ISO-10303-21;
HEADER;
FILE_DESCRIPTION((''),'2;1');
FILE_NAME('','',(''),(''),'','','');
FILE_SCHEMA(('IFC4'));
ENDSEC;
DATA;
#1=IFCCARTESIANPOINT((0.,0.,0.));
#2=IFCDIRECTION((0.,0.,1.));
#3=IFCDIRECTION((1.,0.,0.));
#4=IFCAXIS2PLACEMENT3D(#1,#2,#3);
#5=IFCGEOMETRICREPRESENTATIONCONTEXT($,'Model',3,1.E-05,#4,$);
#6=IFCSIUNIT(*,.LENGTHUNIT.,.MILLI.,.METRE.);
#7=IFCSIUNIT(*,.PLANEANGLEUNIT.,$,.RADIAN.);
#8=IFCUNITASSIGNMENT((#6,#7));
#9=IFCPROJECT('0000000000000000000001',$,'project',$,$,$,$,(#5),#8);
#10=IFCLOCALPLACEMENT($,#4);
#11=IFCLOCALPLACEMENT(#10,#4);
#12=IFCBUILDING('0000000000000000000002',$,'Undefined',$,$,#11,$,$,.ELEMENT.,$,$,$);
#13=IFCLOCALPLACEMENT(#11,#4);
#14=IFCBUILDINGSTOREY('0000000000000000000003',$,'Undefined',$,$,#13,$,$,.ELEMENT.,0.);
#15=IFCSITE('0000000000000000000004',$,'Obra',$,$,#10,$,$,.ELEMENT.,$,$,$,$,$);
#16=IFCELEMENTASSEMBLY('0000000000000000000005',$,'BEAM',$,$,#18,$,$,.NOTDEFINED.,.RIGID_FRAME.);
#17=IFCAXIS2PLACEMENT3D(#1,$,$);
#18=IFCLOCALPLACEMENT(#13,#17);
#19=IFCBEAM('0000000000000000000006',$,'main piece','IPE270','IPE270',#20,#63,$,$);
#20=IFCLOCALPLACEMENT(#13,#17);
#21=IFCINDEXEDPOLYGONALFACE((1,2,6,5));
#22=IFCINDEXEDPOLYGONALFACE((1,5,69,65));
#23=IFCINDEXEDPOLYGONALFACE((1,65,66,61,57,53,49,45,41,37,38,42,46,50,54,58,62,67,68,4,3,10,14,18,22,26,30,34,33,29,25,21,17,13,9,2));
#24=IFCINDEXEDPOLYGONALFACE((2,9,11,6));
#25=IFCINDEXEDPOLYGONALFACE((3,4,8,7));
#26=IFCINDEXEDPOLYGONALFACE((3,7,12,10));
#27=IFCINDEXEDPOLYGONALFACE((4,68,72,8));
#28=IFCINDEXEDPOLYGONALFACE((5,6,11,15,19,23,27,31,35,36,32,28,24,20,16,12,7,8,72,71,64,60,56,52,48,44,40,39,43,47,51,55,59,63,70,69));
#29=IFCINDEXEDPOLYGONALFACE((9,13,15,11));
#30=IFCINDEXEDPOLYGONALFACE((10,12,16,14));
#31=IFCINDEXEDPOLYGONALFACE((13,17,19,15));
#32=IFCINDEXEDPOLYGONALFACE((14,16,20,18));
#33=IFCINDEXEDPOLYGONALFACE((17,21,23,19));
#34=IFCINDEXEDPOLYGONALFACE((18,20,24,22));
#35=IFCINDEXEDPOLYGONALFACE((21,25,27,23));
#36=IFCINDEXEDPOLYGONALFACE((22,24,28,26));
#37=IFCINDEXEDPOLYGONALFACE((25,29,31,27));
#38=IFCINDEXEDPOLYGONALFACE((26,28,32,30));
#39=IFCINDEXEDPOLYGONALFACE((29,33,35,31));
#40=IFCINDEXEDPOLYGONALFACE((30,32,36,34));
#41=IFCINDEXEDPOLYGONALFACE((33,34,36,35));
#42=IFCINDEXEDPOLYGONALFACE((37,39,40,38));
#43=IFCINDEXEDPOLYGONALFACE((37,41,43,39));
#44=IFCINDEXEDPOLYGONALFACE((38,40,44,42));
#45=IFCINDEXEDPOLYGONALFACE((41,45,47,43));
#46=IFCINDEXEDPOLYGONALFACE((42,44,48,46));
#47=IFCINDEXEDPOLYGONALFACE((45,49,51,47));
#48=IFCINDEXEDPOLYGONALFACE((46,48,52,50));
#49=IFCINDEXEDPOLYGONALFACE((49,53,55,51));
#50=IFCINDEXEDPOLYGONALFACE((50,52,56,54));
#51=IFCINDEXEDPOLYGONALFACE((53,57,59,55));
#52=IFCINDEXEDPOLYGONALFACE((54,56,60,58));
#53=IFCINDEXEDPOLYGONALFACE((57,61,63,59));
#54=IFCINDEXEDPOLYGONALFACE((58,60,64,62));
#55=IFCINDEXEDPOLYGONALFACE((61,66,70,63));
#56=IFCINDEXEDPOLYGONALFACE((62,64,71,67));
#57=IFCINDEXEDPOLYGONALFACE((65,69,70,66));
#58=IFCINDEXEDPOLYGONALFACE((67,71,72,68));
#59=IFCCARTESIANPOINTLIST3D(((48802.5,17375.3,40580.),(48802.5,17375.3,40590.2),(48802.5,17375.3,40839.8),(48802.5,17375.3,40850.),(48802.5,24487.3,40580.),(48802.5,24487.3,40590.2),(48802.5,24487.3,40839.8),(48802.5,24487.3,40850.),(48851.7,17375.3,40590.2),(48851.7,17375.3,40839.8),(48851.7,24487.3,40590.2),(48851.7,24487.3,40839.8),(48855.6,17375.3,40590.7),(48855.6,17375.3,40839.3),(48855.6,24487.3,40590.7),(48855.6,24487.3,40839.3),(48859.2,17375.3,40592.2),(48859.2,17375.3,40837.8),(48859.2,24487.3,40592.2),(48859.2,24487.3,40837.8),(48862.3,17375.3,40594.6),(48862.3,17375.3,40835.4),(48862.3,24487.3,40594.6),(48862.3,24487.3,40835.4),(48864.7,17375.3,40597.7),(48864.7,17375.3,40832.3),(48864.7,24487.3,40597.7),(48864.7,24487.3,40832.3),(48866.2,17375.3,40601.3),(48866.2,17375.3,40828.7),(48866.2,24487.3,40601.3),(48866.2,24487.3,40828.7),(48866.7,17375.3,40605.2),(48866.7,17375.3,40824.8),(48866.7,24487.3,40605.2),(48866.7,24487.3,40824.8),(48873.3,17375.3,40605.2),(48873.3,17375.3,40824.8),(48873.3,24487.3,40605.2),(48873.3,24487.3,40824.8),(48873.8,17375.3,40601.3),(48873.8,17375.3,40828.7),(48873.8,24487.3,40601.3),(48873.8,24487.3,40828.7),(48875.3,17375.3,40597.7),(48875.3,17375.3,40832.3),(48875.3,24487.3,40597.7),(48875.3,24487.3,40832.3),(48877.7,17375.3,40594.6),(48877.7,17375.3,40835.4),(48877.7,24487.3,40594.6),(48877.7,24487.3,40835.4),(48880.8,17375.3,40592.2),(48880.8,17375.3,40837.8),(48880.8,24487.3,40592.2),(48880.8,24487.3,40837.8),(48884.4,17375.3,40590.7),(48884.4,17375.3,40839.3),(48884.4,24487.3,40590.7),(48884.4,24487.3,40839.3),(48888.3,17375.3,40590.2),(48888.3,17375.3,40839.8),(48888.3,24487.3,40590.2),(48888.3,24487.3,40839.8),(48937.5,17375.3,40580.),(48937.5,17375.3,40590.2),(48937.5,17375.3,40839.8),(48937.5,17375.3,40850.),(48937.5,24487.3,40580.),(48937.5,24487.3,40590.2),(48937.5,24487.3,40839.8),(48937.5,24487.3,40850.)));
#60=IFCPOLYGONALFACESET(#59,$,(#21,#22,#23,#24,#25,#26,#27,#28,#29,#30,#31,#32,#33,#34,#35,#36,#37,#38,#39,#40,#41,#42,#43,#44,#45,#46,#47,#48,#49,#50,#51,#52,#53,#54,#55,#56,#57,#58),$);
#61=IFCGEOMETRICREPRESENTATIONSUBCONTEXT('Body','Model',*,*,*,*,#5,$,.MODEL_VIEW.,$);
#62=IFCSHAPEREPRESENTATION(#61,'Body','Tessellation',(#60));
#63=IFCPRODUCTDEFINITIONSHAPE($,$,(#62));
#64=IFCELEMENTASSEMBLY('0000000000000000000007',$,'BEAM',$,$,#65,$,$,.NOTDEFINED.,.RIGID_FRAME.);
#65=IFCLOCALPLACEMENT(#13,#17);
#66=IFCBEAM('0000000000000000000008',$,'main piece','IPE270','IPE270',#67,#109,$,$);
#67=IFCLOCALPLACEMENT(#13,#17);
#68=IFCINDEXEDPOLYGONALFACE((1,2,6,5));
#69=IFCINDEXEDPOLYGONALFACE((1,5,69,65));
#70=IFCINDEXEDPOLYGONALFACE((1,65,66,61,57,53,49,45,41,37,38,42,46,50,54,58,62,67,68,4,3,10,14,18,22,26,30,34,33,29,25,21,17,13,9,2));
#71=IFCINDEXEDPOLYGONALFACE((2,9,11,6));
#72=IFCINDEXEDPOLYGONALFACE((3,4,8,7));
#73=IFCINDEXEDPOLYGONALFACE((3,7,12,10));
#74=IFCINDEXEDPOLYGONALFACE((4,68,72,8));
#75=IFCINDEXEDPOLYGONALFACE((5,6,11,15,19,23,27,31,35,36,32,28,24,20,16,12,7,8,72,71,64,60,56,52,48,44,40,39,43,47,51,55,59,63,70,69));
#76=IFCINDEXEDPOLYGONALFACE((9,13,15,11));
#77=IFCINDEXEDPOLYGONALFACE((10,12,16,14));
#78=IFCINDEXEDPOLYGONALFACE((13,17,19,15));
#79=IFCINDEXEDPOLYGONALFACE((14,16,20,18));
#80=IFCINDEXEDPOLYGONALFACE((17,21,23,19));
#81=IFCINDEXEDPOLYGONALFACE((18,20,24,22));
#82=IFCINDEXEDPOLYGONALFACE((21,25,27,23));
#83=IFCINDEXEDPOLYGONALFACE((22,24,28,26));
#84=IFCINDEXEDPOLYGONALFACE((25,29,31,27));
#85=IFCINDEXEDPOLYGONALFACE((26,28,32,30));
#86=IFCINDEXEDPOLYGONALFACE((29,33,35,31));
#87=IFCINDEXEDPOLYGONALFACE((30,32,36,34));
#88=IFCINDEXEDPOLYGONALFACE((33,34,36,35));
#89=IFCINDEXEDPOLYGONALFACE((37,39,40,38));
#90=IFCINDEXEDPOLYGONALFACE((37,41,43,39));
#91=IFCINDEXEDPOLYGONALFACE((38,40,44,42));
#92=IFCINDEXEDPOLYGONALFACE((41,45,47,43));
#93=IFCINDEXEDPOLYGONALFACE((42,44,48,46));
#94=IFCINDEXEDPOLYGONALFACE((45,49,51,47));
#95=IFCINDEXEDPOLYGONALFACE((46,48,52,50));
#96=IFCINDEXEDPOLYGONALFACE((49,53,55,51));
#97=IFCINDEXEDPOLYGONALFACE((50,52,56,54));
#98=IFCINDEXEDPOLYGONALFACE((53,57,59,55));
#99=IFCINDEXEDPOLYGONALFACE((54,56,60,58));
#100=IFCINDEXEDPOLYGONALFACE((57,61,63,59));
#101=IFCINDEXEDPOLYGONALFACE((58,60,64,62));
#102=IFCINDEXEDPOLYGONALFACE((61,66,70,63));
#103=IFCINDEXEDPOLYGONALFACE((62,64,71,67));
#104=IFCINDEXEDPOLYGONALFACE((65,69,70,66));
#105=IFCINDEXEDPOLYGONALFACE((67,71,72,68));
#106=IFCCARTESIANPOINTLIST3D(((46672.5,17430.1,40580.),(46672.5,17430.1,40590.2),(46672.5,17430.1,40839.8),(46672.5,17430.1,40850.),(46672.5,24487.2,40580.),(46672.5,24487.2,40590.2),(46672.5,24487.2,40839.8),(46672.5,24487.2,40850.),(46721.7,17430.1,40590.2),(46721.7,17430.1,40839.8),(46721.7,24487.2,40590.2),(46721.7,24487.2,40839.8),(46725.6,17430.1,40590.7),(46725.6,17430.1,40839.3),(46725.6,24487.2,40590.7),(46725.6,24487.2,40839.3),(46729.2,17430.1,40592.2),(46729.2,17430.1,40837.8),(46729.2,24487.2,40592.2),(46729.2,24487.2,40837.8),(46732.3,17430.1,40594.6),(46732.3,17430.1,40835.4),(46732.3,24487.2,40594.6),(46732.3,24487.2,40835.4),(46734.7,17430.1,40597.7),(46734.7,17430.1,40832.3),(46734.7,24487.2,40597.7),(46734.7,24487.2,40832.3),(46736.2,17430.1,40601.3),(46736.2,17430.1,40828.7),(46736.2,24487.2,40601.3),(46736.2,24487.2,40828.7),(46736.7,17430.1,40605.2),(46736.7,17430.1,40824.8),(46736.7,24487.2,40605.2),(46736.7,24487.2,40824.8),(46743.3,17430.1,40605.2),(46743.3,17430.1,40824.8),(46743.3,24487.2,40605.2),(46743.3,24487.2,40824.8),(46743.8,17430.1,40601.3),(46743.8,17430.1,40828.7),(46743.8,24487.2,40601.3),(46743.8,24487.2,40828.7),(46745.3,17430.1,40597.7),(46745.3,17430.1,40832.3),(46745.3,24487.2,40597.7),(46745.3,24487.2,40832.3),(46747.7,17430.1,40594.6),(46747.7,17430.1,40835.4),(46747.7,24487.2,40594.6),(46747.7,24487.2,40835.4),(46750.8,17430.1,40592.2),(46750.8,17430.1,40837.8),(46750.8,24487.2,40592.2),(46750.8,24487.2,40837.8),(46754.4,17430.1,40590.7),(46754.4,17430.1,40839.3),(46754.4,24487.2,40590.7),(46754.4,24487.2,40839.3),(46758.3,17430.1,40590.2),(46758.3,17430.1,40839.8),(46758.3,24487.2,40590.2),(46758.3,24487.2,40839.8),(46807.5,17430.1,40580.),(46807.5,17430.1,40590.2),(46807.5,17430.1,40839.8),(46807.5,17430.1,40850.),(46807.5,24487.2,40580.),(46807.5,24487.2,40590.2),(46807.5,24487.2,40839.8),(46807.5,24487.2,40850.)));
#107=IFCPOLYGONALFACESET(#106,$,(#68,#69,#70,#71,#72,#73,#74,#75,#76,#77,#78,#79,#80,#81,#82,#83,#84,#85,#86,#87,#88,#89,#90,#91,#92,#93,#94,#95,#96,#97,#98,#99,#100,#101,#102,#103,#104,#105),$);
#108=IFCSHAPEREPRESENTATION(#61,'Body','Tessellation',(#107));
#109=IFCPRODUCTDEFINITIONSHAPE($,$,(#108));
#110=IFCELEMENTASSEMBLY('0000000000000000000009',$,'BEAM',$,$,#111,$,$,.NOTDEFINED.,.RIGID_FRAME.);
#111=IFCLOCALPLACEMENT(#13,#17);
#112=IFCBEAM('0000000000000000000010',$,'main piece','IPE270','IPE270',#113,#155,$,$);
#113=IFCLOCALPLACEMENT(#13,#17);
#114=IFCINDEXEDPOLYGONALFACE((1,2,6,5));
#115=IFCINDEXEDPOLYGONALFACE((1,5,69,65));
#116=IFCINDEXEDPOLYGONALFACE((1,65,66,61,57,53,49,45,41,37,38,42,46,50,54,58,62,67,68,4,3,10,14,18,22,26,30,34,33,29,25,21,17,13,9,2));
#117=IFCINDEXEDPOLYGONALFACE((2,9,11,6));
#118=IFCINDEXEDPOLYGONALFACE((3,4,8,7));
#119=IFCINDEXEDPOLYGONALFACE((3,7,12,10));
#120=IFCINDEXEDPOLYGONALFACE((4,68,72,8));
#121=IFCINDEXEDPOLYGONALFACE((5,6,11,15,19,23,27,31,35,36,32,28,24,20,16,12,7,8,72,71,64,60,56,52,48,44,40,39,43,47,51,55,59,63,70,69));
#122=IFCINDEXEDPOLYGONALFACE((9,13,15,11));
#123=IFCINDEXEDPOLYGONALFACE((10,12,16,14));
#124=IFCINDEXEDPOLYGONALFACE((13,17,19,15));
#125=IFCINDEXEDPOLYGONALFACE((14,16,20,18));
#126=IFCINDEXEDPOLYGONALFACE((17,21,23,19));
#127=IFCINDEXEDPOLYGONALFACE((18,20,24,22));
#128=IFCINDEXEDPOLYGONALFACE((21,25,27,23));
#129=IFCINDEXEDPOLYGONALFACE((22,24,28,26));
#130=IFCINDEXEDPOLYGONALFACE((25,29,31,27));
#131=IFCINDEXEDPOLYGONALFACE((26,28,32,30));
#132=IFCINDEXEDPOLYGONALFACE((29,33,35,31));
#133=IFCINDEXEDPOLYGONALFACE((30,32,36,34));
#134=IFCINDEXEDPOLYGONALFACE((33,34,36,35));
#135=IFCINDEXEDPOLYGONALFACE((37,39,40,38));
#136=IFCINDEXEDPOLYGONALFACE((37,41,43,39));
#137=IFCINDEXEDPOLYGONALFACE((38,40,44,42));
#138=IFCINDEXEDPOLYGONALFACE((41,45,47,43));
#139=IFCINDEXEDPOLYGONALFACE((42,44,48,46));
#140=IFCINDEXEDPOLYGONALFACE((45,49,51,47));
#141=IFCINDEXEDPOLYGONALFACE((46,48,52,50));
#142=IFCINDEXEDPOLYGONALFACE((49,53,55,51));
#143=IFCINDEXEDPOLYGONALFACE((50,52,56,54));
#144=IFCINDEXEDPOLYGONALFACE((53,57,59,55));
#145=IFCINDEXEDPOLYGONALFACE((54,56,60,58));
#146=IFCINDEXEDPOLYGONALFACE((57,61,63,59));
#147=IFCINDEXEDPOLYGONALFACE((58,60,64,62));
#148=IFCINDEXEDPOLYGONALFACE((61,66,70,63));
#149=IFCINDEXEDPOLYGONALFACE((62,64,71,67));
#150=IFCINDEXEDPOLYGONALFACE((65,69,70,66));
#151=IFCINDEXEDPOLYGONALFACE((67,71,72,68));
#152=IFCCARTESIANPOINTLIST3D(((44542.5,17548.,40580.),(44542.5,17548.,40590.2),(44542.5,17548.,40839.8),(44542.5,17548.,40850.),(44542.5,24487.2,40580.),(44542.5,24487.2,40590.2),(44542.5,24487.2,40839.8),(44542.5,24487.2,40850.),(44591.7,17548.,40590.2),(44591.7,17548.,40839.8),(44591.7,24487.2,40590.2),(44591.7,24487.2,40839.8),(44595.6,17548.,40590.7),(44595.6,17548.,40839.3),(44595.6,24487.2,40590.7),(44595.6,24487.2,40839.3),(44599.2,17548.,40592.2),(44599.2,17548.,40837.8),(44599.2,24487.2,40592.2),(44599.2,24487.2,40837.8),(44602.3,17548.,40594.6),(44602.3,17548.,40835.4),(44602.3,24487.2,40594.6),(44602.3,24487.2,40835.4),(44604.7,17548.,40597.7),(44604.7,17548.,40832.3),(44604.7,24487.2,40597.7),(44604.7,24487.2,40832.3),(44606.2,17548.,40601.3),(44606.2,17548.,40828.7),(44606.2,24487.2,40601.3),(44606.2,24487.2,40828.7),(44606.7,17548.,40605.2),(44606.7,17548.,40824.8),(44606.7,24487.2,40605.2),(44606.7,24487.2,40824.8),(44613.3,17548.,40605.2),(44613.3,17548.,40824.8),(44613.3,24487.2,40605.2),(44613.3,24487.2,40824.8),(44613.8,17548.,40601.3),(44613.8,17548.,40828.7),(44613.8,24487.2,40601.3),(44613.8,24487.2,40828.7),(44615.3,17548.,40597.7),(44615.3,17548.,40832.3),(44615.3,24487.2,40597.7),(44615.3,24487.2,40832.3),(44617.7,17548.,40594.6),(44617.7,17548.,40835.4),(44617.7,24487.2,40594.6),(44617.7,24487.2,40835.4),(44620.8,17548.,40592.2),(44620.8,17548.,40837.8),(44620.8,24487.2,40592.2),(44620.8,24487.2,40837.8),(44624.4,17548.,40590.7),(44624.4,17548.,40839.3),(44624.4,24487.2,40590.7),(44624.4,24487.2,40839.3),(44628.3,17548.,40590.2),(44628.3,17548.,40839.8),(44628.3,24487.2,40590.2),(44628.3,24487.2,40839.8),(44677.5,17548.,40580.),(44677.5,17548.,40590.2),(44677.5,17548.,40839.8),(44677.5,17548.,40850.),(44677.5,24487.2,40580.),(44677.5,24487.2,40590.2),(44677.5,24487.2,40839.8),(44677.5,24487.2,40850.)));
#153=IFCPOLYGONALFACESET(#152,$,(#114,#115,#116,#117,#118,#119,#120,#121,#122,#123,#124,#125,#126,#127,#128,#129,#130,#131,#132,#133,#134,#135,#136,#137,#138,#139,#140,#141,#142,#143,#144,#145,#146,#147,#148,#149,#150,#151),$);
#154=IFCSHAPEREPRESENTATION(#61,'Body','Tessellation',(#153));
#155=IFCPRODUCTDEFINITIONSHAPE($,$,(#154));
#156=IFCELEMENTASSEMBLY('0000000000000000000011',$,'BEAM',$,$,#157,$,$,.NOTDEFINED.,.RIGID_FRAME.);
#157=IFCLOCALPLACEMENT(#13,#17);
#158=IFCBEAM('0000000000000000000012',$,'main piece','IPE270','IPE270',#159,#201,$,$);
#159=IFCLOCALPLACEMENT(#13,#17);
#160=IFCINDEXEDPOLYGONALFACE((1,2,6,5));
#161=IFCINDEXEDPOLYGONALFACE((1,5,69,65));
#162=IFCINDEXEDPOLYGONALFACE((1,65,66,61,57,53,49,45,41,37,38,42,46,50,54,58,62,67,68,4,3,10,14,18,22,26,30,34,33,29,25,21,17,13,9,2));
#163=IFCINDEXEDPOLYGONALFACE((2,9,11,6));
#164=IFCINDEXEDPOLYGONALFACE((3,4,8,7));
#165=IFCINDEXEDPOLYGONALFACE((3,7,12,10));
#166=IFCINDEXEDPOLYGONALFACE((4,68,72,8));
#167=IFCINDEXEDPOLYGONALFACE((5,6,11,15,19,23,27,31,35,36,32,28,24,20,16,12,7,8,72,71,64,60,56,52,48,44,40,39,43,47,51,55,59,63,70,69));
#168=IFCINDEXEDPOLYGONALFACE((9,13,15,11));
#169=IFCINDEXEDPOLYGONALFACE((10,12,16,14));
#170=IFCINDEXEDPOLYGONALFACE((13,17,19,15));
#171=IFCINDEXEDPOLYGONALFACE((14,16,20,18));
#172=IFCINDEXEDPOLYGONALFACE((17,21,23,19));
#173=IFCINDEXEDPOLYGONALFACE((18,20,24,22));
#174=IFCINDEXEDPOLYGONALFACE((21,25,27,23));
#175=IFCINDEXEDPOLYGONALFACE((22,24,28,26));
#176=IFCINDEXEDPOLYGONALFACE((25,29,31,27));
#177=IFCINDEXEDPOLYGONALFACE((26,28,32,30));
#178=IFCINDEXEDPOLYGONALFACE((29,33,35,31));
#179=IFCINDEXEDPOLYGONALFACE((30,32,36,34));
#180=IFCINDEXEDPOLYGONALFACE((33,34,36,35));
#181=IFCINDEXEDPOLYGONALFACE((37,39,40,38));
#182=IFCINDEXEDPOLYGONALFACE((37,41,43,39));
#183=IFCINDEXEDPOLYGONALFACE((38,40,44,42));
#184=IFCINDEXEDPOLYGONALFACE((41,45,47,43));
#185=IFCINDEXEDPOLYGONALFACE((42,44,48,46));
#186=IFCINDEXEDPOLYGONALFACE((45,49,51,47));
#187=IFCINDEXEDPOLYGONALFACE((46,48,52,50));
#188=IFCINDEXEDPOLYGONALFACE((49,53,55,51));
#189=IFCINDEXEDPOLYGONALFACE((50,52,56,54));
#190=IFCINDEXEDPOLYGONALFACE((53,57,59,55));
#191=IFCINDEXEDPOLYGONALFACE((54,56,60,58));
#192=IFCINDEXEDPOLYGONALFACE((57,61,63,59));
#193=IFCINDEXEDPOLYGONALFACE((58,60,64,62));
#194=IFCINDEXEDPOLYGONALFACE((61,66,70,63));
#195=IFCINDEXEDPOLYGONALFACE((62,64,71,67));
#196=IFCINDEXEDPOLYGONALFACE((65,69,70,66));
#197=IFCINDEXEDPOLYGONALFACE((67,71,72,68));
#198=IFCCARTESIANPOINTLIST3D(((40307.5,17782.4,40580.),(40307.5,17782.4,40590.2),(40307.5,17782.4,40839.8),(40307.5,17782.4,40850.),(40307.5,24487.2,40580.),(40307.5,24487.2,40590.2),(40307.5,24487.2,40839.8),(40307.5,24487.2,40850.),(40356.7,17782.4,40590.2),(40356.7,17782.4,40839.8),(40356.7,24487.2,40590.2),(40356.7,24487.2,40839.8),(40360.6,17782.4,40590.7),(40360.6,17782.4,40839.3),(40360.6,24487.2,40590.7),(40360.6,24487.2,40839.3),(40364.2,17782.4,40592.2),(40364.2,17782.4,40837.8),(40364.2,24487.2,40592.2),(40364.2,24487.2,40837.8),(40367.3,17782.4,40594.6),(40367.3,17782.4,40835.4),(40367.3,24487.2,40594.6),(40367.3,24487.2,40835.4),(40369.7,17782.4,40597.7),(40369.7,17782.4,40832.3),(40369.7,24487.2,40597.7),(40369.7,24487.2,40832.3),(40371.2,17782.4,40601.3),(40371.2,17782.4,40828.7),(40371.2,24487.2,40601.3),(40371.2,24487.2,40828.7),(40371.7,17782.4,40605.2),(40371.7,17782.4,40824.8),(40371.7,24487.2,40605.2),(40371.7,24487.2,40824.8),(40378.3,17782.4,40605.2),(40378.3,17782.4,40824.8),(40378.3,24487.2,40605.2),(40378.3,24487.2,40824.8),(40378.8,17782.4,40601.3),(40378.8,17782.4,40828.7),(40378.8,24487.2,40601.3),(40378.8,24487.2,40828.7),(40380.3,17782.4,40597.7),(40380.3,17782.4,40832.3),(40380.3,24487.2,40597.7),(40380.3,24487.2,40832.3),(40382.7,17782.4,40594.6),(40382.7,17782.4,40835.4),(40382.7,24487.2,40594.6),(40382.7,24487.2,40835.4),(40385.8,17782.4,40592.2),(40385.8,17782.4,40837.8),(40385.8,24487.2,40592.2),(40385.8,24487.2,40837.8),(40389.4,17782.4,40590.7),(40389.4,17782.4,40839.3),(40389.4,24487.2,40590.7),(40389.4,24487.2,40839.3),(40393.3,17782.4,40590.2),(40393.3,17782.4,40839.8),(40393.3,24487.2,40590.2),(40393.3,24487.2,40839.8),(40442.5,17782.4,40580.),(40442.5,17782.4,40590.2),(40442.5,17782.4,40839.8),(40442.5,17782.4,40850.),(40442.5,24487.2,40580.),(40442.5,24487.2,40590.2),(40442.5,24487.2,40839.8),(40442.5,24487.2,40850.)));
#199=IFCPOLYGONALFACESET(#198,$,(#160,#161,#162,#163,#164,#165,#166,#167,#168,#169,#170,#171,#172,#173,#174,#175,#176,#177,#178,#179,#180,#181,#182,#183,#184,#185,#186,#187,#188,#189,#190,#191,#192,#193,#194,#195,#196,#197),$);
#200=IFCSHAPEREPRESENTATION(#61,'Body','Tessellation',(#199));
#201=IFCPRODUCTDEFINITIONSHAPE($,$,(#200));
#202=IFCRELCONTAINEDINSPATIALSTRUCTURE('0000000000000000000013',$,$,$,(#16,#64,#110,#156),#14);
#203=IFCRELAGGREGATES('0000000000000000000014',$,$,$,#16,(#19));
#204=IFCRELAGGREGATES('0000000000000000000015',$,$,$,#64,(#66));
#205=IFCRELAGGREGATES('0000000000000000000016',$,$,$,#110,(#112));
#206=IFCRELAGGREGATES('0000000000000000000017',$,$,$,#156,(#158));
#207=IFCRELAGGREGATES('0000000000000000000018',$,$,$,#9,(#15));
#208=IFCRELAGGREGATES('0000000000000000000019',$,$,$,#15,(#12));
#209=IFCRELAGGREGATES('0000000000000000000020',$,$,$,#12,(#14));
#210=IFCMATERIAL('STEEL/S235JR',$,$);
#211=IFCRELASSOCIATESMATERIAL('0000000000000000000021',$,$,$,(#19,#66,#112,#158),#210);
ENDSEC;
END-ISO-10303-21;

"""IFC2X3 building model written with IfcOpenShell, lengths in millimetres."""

from ifc_helpers import new_model, si_unit, frame, origin_with_axes, origin_2d_with_axis, place, context, subcontext, project, spatial, i_section, extrude, material, element, aggregate, save


model = new_model("IFC2X3")

# Units and contexts
model_context = context("Model", 3, precision=1e-05, world=origin_with_axes())
body_context = subcontext(model_context, "Body", "Model", "MODEL_VIEW")
ifc_project = project(units=[si_unit("LENGTHUNIT", "METRE", prefix="MILLI"), si_unit("PLANEANGLEUNIT", "RADIAN")], contexts=[model_context])

# Site, building, storey
site_placement = place(None, origin_with_axes())
site = spatial("IfcSite", under=ifc_project, at=site_placement, Name="Obra", CompositionType="ELEMENT")
building_placement = place(site_placement, origin_with_axes())
building = spatial("IfcBuilding", under=site, at=building_placement, Name="Undefined", CompositionType="ELEMENT")
storey_placement = place(building_placement, origin_with_axes())
storey = spatial("IfcBuildingStorey", under=building, at=storey_placement, Name="Undefined", CompositionType="ELEMENT", Elevation=0.0)

# Element assemblies, beams
ifc_material_1 = material(Name="STEEL/S235JR")
assembly_1_placement = place(storey_placement, origin_with_axes())
assembly_1 = element("IfcElementAssembly", 1, at=assembly_1_placement, inside=storey, Name="BEAM", AssemblyPlace="NOTDEFINED", PredefinedType="RIGID_FRAME")
beam_1_placement = place(assembly_1_placement, frame((48870.0, 17375.3, 40715.0), z_axis=(0.0, 0.0, 1.0), x_axis=(0.0, 1.0, 0.0)))
beam_1 = element("IfcBeam", 2, at=beam_1_placement, material=ifc_material_1, Name="main piece", Description="IPE270", ObjectType="IPE270", context=body_context, shape_type="SweptSolid", body=[
    extrude(i_section(OverallWidth=135.0, OverallDepth=270.0, WebThickness=6.6, FlangeThickness=10.2, FilletRadius=15.0, at=origin_2d_with_axis()), frame((7112.0, 0.0, 0.0), z_axis=(-1.0, 0.0, 0.0), x_axis=(0.0, -1.0, 0.0)), (0.0, 0.0, 1.0), 7112.0),
])
aggregate(assembly_1, [beam_1])
assembly_2_placement = place(storey_placement, origin_with_axes())
assembly_2 = element("IfcElementAssembly", 3, at=assembly_2_placement, inside=storey, Name="BEAM", AssemblyPlace="NOTDEFINED", PredefinedType="RIGID_FRAME")
beam_2_placement = place(assembly_2_placement, frame((46740.0, 24487.2, 40715.0), z_axis=(0.0, 0.0, 1.0), x_axis=(0.0, -1.0, 0.0)))
beam_2 = element("IfcBeam", 4, at=beam_2_placement, material=ifc_material_1, Name="main piece", Description="IPE270", ObjectType="IPE270", context=body_context, shape_type="SweptSolid", body=[
    extrude(i_section(OverallWidth=135.0, OverallDepth=270.0, WebThickness=6.6, FlangeThickness=10.2, FilletRadius=15.0, at=origin_2d_with_axis()), frame((7057.1, 0.0, 0.0), z_axis=(-1.0, 0.0, 0.0), x_axis=(0.0, -1.0, 0.0)), (0.0, 0.0, 1.0), 7057.1),
])
aggregate(assembly_2, [beam_2])
assembly_3_placement = place(storey_placement, origin_with_axes())
assembly_3 = element("IfcElementAssembly", 5, at=assembly_3_placement, inside=storey, Name="BEAM", AssemblyPlace="NOTDEFINED", PredefinedType="RIGID_FRAME")
beam_3_placement = place(assembly_3_placement, frame((44610.0, 17548.0, 40715.0), z_axis=(0.0, 0.0, 1.0), x_axis=(0.0, 1.0, 0.0)))
beam_3 = element("IfcBeam", 6, at=beam_3_placement, material=ifc_material_1, Name="main piece", Description="IPE270", ObjectType="IPE270", context=body_context, shape_type="SweptSolid", body=[
    extrude(i_section(OverallWidth=135.0, OverallDepth=270.0, WebThickness=6.6, FlangeThickness=10.2, FilletRadius=15.0, at=origin_2d_with_axis()), frame((6939.2, 0.0, 0.0), z_axis=(-1.0, 0.0, 0.0), x_axis=(0.0, -1.0, 0.0)), (0.0, 0.0, 1.0), 6939.2),
])
aggregate(assembly_3, [beam_3])
assembly_4_placement = place(storey_placement, origin_with_axes())
assembly_4 = element("IfcElementAssembly", 7, at=assembly_4_placement, inside=storey, Name="BEAM", AssemblyPlace="NOTDEFINED", PredefinedType="RIGID_FRAME")
beam_4_placement = place(assembly_4_placement, frame((40375.0, 17782.4, 40715.0), z_axis=(0.0, 0.0, 1.0), x_axis=(0.0, 1.0, 0.0)))
beam_4 = element("IfcBeam", 8, at=beam_4_placement, material=ifc_material_1, Name="main piece", Description="IPE270", ObjectType="IPE270", context=body_context, shape_type="SweptSolid", body=[
    extrude(i_section(OverallWidth=135.0, OverallDepth=270.0, WebThickness=6.6, FlangeThickness=10.2, FilletRadius=15.0, at=origin_2d_with_axis()), frame((6704.8, 0.0, 0.0), z_axis=(-1.0, 0.0, 0.0), x_axis=(0.0, -1.0, 0.0)), (0.0, 0.0, 1.0), 6704.8),
])
aggregate(assembly_4, [beam_4])

save(model, "model.ifc")
